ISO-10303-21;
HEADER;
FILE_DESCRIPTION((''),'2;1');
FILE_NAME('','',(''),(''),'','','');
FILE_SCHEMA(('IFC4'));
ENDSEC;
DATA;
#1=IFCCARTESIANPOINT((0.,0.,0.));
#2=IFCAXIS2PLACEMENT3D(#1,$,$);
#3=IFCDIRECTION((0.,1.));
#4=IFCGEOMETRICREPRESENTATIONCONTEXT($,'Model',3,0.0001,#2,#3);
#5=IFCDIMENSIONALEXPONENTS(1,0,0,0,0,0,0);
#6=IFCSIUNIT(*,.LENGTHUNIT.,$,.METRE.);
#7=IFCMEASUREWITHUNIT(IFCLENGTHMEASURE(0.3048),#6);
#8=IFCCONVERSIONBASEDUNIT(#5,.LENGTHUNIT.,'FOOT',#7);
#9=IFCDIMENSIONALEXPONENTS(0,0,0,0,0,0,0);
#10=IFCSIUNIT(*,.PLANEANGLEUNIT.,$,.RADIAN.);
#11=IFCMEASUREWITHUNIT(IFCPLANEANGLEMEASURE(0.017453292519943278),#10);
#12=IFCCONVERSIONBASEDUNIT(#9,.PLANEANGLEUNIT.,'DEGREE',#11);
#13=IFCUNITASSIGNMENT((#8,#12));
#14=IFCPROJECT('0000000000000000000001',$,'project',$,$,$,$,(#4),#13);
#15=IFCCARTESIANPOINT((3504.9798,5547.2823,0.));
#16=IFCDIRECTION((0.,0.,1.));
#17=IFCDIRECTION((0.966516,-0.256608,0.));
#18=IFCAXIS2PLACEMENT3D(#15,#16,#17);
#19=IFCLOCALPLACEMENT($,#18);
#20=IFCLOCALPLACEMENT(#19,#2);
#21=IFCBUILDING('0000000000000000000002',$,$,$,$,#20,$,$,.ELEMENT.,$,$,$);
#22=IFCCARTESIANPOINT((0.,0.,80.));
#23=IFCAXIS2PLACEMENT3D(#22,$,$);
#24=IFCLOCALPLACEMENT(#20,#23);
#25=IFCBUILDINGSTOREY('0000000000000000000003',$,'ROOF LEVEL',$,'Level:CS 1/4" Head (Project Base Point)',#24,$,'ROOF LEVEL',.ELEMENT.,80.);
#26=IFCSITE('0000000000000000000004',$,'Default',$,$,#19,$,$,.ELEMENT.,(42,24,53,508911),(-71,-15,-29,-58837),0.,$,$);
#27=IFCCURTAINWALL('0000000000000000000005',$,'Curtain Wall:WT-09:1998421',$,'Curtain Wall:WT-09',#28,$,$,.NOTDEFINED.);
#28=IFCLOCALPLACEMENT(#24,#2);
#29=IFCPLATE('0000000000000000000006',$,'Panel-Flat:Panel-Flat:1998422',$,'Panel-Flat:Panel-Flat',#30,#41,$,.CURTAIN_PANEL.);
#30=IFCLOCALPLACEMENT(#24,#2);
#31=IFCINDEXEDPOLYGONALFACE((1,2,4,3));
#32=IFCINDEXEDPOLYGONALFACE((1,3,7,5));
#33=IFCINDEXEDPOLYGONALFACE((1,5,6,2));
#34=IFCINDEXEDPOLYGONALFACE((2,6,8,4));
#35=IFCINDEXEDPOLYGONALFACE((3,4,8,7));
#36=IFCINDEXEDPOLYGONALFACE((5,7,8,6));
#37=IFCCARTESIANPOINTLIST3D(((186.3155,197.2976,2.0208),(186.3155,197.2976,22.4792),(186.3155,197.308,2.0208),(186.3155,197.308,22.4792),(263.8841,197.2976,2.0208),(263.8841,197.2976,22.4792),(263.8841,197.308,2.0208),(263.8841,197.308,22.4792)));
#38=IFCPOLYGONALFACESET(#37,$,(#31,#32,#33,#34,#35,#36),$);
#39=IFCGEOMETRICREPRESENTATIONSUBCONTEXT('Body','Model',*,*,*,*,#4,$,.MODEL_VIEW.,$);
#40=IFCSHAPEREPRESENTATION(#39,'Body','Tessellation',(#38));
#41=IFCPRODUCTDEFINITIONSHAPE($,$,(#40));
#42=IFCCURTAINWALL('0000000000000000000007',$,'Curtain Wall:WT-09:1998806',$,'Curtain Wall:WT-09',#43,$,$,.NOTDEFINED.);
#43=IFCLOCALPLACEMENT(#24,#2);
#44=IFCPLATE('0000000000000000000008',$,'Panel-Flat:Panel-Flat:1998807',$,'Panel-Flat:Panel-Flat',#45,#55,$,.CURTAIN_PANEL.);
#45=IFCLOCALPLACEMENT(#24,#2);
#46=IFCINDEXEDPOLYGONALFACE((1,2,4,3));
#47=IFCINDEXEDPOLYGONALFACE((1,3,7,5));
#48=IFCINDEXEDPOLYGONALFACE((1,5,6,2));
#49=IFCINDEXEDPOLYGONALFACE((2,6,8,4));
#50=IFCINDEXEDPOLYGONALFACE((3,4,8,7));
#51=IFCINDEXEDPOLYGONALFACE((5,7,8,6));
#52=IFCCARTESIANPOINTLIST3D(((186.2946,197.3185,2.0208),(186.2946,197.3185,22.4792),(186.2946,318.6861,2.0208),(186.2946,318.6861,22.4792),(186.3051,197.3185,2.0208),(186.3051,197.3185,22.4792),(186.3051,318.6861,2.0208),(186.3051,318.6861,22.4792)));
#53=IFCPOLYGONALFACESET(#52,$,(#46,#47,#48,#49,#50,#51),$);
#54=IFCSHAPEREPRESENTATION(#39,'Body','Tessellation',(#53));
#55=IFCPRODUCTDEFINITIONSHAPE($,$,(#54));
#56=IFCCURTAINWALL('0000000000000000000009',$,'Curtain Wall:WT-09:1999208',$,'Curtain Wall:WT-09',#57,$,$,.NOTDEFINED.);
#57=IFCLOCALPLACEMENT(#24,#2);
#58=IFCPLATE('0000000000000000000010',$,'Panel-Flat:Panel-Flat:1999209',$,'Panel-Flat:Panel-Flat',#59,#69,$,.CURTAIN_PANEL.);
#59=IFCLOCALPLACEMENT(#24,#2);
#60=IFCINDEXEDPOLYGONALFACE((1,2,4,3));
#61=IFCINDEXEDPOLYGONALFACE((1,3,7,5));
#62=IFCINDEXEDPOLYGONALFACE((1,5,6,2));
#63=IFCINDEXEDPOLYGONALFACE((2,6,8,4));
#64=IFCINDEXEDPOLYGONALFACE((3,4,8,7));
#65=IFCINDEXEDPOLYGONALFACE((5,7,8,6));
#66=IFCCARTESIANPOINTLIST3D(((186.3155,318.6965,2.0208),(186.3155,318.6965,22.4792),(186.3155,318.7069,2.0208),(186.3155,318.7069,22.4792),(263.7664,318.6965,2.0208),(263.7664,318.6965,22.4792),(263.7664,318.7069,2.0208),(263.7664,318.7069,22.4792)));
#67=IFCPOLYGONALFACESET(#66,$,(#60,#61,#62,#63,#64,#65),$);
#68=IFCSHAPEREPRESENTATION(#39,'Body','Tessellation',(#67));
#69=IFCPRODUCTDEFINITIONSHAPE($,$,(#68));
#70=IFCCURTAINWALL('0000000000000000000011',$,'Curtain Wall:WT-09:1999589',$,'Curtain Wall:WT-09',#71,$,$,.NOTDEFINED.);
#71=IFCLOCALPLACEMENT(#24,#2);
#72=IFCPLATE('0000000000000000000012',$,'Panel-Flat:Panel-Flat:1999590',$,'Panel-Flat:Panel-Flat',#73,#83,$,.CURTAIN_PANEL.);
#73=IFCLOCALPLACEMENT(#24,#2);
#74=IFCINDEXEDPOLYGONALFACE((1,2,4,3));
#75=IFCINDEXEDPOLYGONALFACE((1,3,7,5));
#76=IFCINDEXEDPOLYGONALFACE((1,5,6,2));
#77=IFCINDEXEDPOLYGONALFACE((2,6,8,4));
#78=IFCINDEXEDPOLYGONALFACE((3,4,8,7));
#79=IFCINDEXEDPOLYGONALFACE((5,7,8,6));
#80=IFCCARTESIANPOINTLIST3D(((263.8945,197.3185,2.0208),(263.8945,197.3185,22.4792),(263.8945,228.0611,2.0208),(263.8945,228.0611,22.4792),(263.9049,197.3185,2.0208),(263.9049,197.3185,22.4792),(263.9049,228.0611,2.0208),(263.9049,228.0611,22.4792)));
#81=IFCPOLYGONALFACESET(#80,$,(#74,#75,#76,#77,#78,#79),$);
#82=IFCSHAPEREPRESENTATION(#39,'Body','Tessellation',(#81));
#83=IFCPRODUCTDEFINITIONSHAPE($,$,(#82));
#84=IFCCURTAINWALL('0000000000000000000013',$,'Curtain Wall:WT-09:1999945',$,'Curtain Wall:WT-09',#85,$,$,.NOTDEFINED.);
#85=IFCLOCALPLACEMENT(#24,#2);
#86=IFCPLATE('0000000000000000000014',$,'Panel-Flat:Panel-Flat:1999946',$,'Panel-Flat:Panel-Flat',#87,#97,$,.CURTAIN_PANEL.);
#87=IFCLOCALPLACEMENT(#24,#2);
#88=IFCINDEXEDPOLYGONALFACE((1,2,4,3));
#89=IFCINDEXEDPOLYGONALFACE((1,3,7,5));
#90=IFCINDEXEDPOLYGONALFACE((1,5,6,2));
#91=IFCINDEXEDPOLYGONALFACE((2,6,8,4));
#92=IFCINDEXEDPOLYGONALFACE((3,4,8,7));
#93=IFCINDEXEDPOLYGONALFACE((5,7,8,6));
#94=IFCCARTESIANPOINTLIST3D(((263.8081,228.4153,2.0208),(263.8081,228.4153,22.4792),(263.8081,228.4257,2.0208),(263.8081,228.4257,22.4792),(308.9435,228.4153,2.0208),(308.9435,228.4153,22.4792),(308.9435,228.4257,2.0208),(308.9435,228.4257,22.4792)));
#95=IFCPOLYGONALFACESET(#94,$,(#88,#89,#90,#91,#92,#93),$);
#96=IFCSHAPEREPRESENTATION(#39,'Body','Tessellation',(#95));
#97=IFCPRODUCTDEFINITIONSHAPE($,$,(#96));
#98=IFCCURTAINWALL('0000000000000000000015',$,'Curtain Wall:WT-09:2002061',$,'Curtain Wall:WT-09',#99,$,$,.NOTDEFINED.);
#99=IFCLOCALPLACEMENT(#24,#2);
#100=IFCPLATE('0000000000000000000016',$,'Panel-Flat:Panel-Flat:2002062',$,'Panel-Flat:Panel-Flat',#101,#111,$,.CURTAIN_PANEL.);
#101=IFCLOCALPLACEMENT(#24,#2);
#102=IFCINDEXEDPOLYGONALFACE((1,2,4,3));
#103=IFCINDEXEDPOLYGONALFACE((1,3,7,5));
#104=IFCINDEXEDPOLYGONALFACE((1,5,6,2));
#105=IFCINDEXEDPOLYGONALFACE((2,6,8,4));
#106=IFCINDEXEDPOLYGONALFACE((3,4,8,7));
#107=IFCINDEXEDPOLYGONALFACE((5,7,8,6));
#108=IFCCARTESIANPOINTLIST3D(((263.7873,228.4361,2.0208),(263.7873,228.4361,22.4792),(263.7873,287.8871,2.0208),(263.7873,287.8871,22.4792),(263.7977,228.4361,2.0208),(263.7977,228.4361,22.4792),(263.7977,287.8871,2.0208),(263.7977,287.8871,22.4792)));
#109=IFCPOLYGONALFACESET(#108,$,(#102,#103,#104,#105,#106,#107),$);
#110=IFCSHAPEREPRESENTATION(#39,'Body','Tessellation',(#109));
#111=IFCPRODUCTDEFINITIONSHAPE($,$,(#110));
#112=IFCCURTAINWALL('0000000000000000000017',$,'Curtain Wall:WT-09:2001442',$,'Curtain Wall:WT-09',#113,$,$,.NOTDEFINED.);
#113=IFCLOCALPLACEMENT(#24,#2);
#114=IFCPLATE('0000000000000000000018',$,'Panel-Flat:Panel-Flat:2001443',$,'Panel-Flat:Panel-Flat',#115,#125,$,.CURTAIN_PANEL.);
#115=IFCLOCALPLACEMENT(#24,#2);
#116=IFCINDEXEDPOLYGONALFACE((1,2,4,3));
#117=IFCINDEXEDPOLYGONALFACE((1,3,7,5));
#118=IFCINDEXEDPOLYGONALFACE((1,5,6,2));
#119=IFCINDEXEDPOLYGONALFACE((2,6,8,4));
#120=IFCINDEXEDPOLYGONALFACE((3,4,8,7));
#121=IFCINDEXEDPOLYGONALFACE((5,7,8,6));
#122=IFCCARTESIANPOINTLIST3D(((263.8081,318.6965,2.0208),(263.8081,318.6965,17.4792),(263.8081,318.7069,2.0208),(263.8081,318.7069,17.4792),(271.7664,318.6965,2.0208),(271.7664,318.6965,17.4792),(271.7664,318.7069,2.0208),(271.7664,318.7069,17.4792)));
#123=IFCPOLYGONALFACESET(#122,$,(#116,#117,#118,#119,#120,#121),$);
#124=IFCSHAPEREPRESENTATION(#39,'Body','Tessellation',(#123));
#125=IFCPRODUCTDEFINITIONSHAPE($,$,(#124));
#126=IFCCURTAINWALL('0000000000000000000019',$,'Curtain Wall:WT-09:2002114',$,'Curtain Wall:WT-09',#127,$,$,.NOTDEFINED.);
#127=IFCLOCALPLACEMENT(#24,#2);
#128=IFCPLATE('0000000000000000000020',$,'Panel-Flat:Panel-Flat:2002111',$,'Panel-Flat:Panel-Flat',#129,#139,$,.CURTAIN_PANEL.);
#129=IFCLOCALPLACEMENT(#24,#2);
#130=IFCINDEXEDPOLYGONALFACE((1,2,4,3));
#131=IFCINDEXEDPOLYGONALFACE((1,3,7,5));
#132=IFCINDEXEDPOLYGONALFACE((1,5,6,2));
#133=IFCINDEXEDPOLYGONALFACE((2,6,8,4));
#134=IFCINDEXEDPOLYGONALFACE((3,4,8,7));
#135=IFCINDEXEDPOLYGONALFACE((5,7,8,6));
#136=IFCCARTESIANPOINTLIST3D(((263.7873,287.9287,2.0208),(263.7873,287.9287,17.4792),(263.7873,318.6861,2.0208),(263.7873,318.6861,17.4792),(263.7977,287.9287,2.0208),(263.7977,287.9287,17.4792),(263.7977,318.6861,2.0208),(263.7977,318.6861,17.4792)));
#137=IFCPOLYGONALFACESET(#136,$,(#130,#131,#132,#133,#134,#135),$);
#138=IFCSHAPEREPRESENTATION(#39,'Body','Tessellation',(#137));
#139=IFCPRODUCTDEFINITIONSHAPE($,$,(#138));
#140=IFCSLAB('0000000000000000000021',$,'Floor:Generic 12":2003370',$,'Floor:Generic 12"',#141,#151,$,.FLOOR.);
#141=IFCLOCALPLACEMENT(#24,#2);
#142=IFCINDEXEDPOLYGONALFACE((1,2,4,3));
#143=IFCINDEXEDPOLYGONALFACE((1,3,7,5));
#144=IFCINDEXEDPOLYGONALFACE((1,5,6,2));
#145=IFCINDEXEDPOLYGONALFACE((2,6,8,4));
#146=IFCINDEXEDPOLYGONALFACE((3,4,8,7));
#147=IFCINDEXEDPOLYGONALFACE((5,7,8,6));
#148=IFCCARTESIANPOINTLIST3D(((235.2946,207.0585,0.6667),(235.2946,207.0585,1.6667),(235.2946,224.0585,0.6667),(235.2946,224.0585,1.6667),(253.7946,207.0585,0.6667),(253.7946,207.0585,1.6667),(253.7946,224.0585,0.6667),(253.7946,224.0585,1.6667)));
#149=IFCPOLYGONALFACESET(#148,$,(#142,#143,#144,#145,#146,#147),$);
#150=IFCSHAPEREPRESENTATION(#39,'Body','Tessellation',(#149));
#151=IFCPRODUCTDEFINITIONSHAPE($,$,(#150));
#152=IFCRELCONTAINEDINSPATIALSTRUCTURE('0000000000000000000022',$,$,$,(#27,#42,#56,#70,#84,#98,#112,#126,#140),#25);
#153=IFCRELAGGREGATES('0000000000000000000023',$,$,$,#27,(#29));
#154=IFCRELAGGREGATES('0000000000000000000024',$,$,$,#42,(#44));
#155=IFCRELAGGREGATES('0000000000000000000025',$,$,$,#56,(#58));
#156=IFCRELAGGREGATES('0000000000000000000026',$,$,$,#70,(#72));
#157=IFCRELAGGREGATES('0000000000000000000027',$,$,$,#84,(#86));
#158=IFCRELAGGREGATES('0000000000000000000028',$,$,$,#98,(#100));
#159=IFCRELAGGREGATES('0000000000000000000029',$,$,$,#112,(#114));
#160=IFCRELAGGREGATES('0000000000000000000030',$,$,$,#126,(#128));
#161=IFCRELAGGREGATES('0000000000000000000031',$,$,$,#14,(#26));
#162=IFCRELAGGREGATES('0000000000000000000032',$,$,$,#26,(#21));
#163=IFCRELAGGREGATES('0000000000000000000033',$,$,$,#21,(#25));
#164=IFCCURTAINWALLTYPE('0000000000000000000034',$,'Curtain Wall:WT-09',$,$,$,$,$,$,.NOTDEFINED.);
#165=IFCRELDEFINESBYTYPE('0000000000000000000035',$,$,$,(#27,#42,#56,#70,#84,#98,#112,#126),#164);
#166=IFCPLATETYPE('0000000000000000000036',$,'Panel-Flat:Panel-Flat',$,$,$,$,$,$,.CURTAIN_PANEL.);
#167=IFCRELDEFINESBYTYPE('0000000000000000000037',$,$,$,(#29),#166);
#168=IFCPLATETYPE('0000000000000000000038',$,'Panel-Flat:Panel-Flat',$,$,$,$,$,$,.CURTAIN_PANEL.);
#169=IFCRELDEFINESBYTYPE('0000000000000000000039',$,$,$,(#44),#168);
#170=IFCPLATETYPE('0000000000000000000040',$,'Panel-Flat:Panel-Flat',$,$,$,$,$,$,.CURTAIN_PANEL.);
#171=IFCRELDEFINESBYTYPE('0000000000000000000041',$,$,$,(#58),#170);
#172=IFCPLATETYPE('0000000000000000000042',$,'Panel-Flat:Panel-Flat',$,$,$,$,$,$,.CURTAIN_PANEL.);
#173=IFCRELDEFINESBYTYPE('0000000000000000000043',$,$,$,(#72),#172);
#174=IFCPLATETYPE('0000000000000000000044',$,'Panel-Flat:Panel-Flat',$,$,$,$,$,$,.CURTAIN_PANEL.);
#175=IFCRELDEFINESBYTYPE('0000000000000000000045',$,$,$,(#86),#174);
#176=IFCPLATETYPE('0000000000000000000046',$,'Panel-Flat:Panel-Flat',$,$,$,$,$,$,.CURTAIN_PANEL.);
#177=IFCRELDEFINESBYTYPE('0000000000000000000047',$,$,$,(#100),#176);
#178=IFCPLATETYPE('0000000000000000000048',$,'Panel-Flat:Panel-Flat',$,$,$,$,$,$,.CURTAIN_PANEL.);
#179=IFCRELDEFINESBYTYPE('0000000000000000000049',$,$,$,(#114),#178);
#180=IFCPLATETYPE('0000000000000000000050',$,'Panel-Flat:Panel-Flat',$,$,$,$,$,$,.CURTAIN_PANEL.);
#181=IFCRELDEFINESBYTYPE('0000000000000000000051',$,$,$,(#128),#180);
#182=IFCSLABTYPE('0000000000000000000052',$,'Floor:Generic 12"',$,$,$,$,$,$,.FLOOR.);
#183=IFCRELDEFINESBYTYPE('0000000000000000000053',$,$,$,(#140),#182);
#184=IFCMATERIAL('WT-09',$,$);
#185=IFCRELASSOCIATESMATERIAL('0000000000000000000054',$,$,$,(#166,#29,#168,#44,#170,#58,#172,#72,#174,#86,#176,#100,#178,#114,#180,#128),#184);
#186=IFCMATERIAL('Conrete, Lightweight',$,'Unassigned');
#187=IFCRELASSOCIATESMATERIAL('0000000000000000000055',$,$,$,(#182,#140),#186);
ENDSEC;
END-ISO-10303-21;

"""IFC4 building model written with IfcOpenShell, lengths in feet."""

from ifc_helpers import new_model, entity, si_unit, converted_unit, direction, frame, origin, place, context, subcontext, project, spatial, indexed_curve, outline, extrude, source, transform, mapped, material, type_object, type_shapes, element, aggregate, save


model = new_model("IFC4")

# Units and contexts
model_context = context("Model", 3, precision=0.0001, world=origin(), true_north=direction((0.0, 1.0)))
body_context = subcontext(model_context, "Body", "Model", "MODEL_VIEW")
ifc_project = project(units=[converted_unit("LENGTHUNIT", "FOOT", entity("IfcLengthMeasure", 0.3048), si_unit("LENGTHUNIT", "METRE"), dimensions=[1, 0, 0, 0, 0, 0, 0]), converted_unit("PLANEANGLEUNIT", "DEGREE", entity("IfcPlaneAngleMeasure", 0.017453292519943278), si_unit("PLANEANGLEUNIT", "RADIAN"), dimensions=[0, 0, 0, 0, 0, 0, 0])], contexts=[model_context])

# Site, building, storey
site_placement = place(None, frame((3504.9798, 5547.2823, 0.0), z_axis=(0.0, 0.0, 1.0), x_axis=(0.966516, -0.256608, 0.0)))
site = spatial("IfcSite", under=ifc_project, at=site_placement, Name="Default", CompositionType="ELEMENT", RefLatitude=(42, 24, 53, 508911), RefLongitude=(-71, -15, -29, -58837), RefElevation=0.0)
building_placement = place(site_placement, origin())
building = spatial("IfcBuilding", under=site, at=building_placement, CompositionType="ELEMENT")
storey_placement = place(building_placement, frame((0.0, 0.0, 80.0)))
storey = spatial("IfcBuildingStorey", under=building, at=storey_placement, Name="ROOF LEVEL", ObjectType="Level:CS 1/4\" Head (Project Base Point)", LongName="ROOF LEVEL", CompositionType="ELEMENT", Elevation=80.0)

# Curtain walls, plates
curtain_wall_type_1 = type_object("IfcCurtainWallType", Name="Curtain Wall:WT-09", PredefinedType="NOTDEFINED")
curtain_wall_1_placement = place(storey_placement, frame((0.0, 0.0, -80.0)))
curtain_wall_1 = element("IfcCurtainWall", 1, at=curtain_wall_1_placement, inside=storey, type_object=curtain_wall_type_1, Name="Curtain Wall:WT-09:1998421", ObjectType="Curtain Wall:WT-09", PredefinedType="NOTDEFINED")
ifc_material_1 = material(Name="WT-09")
plate_type_1 = type_object("IfcPlateType", Name="Panel-Flat:Panel-Flat", PredefinedType="CURTAIN_PANEL", material=ifc_material_1)
shared_shape_1 = source(origin(), body_context, "Body", "SweptSolid", [
    extrude(outline(indexed_curve([(-0.0052, -38.7843), (0.0052, -38.7843), (0.0052, 38.7843), (-0.0052, 38.7843), (-0.0052, -38.7843)], self_intersect=False)), frame((0.0, -0.0052, 0.0208), z_axis=(0.0, 0.0, 1.0), x_axis=(0.0, -1.0, 0.0)), (0.0, 0.0, 1.0), 20.4583),
])
type_shapes(plate_type_1, [shared_shape_1])
plate_1_placement = place(curtain_wall_1_placement, frame((225.0998, 197.2976, 82.0), z_axis=(0.0, 0.0, 1.0), x_axis=(-1.0, 0.0, 0.0)))
plate_1 = element("IfcPlate", 2, at=plate_1_placement, type_object=plate_type_1, material=ifc_material_1, Name="Panel-Flat:Panel-Flat:1998422", ObjectType="Panel-Flat:Panel-Flat", PredefinedType="CURTAIN_PANEL", context=body_context, shape_type="MappedRepresentation", body=[
    mapped(shared_shape_1, transform((0.0, 0.0, 0.0), scale=1.0)),
])
aggregate(curtain_wall_1, [plate_1])
curtain_wall_2_placement = place(storey_placement, frame((0.0, 0.0, -80.0)))
curtain_wall_2 = element("IfcCurtainWall", 3, at=curtain_wall_2_placement, inside=storey, type_object=curtain_wall_type_1, Name="Curtain Wall:WT-09:1998806", ObjectType="Curtain Wall:WT-09", PredefinedType="NOTDEFINED")
plate_type_2 = type_object("IfcPlateType", Name="Panel-Flat:Panel-Flat", PredefinedType="CURTAIN_PANEL", material=ifc_material_1)
shared_shape_2 = source(origin(), body_context, "Body", "SweptSolid", [
    extrude(outline(indexed_curve([(-0.0052, -60.6838), (0.0052, -60.6838), (0.0052, 60.6838), (-0.0052, 60.6838), (-0.0052, -60.6838)], self_intersect=False)), frame((0.0, -0.0052, 0.0208), z_axis=(0.0, 0.0, 1.0), x_axis=(0.0, -1.0, 0.0)), (0.0, 0.0, 1.0), 20.4583),
])
type_shapes(plate_type_2, [shared_shape_2])
plate_2_placement = place(curtain_wall_2_placement, frame((186.2946, 258.0023, 82.0), z_axis=(0.0, 0.0, 1.0), x_axis=(0.0, 1.0, 0.0)))
plate_2 = element("IfcPlate", 4, at=plate_2_placement, type_object=plate_type_2, material=ifc_material_1, Name="Panel-Flat:Panel-Flat:1998807", ObjectType="Panel-Flat:Panel-Flat", PredefinedType="CURTAIN_PANEL", context=body_context, shape_type="MappedRepresentation", body=[
    mapped(shared_shape_2, transform((0.0, 0.0, 0.0), scale=1.0)),
])
aggregate(curtain_wall_2, [plate_2])
curtain_wall_3_placement = place(storey_placement, frame((0.0, 0.0, -80.0)))
curtain_wall_3 = element("IfcCurtainWall", 5, at=curtain_wall_3_placement, inside=storey, type_object=curtain_wall_type_1, Name="Curtain Wall:WT-09:1999208", ObjectType="Curtain Wall:WT-09", PredefinedType="NOTDEFINED")
plate_type_3 = type_object("IfcPlateType", Name="Panel-Flat:Panel-Flat", PredefinedType="CURTAIN_PANEL", material=ifc_material_1)
shared_shape_3 = source(origin(), body_context, "Body", "SweptSolid", [
    extrude(outline(indexed_curve([(-0.0052, -38.7255), (0.0052, -38.7255), (0.0052, 38.7255), (-0.0052, 38.7255), (-0.0052, -38.7255)], self_intersect=False)), frame((0.0, -0.0052, 0.0208), z_axis=(0.0, 0.0, 1.0), x_axis=(0.0, -1.0, 0.0)), (0.0, 0.0, 1.0), 20.4583),
])
type_shapes(plate_type_3, [shared_shape_3])
plate_3_placement = place(curtain_wall_3_placement, frame((225.041, 318.7069, 82.0)))
plate_3 = element("IfcPlate", 6, at=plate_3_placement, type_object=plate_type_3, material=ifc_material_1, Name="Panel-Flat:Panel-Flat:1999209", ObjectType="Panel-Flat:Panel-Flat", PredefinedType="CURTAIN_PANEL", context=body_context, shape_type="MappedRepresentation", body=[
    mapped(shared_shape_3, transform((0.0, 0.0, 0.0), scale=1.0)),
])
aggregate(curtain_wall_3, [plate_3])
curtain_wall_4_placement = place(storey_placement, frame((0.0, 0.0, -80.0)))
curtain_wall_4 = element("IfcCurtainWall", 7, at=curtain_wall_4_placement, inside=storey, type_object=curtain_wall_type_1, Name="Curtain Wall:WT-09:1999589", ObjectType="Curtain Wall:WT-09", PredefinedType="NOTDEFINED")
plate_type_4 = type_object("IfcPlateType", Name="Panel-Flat:Panel-Flat", PredefinedType="CURTAIN_PANEL", material=ifc_material_1)
shared_shape_4 = source(origin(), body_context, "Body", "SweptSolid", [
    extrude(outline(indexed_curve([(-0.0052, -15.3713), (0.0052, -15.3713), (0.0052, 15.3713), (-0.0052, 15.3713), (-0.0052, -15.3713)], self_intersect=False)), frame((0.0, -0.0052, 0.0208), z_axis=(0.0, 0.0, 1.0), x_axis=(0.0, -1.0, 0.0)), (0.0, 0.0, 1.0), 20.4583),
])
type_shapes(plate_type_4, [shared_shape_4])
plate_4_placement = place(curtain_wall_4_placement, frame((263.9049, 212.6898, 82.0), z_axis=(0.0, 0.0, 1.0), x_axis=(0.0, -1.0, 0.0)))
plate_4 = element("IfcPlate", 8, at=plate_4_placement, type_object=plate_type_4, material=ifc_material_1, Name="Panel-Flat:Panel-Flat:1999590", ObjectType="Panel-Flat:Panel-Flat", PredefinedType="CURTAIN_PANEL", context=body_context, shape_type="MappedRepresentation", body=[
    mapped(shared_shape_4, transform((0.0, 0.0, 0.0), scale=1.0)),
])
aggregate(curtain_wall_4, [plate_4])
curtain_wall_5_placement = place(storey_placement, frame((0.0, 0.0, -80.0)))
curtain_wall_5 = element("IfcCurtainWall", 9, at=curtain_wall_5_placement, inside=storey, type_object=curtain_wall_type_1, Name="Curtain Wall:WT-09:1999945", ObjectType="Curtain Wall:WT-09", PredefinedType="NOTDEFINED")
plate_type_5 = type_object("IfcPlateType", Name="Panel-Flat:Panel-Flat", PredefinedType="CURTAIN_PANEL", material=ifc_material_1)
shared_shape_5 = source(origin(), body_context, "Body", "SweptSolid", [
    extrude(outline(indexed_curve([(-0.0052, -22.5677), (0.0052, -22.5677), (0.0052, 22.5677), (-0.0052, 22.5677), (-0.0052, -22.5677)], self_intersect=False)), frame((0.0, -0.0052, 0.0208), z_axis=(0.0, 0.0, 1.0), x_axis=(0.0, -1.0, 0.0)), (0.0, 0.0, 1.0), 20.4583),
])
type_shapes(plate_type_5, [shared_shape_5])
plate_5_placement = place(curtain_wall_5_placement, frame((286.3758, 228.4153, 82.0), z_axis=(0.0, 0.0, 1.0), x_axis=(-1.0, 0.0, 0.0)))
plate_5 = element("IfcPlate", 10, at=plate_5_placement, type_object=plate_type_5, material=ifc_material_1, Name="Panel-Flat:Panel-Flat:1999946", ObjectType="Panel-Flat:Panel-Flat", PredefinedType="CURTAIN_PANEL", context=body_context, shape_type="MappedRepresentation", body=[
    mapped(shared_shape_5, transform((0.0, 0.0, 0.0), scale=1.0)),
])
aggregate(curtain_wall_5, [plate_5])
curtain_wall_6_placement = place(storey_placement, frame((0.0, 0.0, -80.0)))
curtain_wall_6 = element("IfcCurtainWall", 11, at=curtain_wall_6_placement, inside=storey, type_object=curtain_wall_type_1, Name="Curtain Wall:WT-09:2002061", ObjectType="Curtain Wall:WT-09", PredefinedType="NOTDEFINED")
plate_type_6 = type_object("IfcPlateType", Name="Panel-Flat:Panel-Flat", PredefinedType="CURTAIN_PANEL", material=ifc_material_1)
shared_shape_6 = source(origin(), body_context, "Body", "SweptSolid", [
    extrude(outline(indexed_curve([(-0.0052, -29.7255), (0.0052, -29.7255), (0.0052, 29.7255), (-0.0052, 29.7255), (-0.0052, -29.7255)], self_intersect=False)), frame((0.0, -0.0052, 0.0208), z_axis=(0.0, 0.0, 1.0), x_axis=(0.0, -1.0, 0.0)), (0.0, 0.0, 1.0), 20.4583),
])
type_shapes(plate_type_6, [shared_shape_6])
plate_6_placement = place(curtain_wall_6_placement, frame((263.7873, 258.1616, 82.0), z_axis=(0.0, 0.0, 1.0), x_axis=(0.0, 1.0, 0.0)))
plate_6 = element("IfcPlate", 12, at=plate_6_placement, type_object=plate_type_6, material=ifc_material_1, Name="Panel-Flat:Panel-Flat:2002062", ObjectType="Panel-Flat:Panel-Flat", PredefinedType="CURTAIN_PANEL", context=body_context, shape_type="MappedRepresentation", body=[
    mapped(shared_shape_6, transform((0.0, 0.0, 0.0), scale=1.0)),
])
aggregate(curtain_wall_6, [plate_6])
curtain_wall_7_placement = place(storey_placement, frame((0.0, 0.0, -80.0)))
curtain_wall_7 = element("IfcCurtainWall", 13, at=curtain_wall_7_placement, inside=storey, type_object=curtain_wall_type_1, Name="Curtain Wall:WT-09:2001442", ObjectType="Curtain Wall:WT-09", PredefinedType="NOTDEFINED")
plate_type_7 = type_object("IfcPlateType", Name="Panel-Flat:Panel-Flat", PredefinedType="CURTAIN_PANEL", material=ifc_material_1)
shared_shape_7 = source(origin(), body_context, "Body", "SweptSolid", [
    extrude(outline(indexed_curve([(-0.0052, -3.9792), (0.0052, -3.9792), (0.0052, 3.9792), (-0.0052, 3.9792), (-0.0052, -3.9792)], self_intersect=False)), frame((0.0, -0.0052, 0.0208), z_axis=(0.0, 0.0, 1.0), x_axis=(0.0, -1.0, 0.0)), (0.0, 0.0, 1.0), 15.4583),
])
type_shapes(plate_type_7, [shared_shape_7])
plate_7_placement = place(curtain_wall_7_placement, frame((267.7873, 318.7069, 82.0)))
plate_7 = element("IfcPlate", 14, at=plate_7_placement, type_object=plate_type_7, material=ifc_material_1, Name="Panel-Flat:Panel-Flat:2001443", ObjectType="Panel-Flat:Panel-Flat", PredefinedType="CURTAIN_PANEL", context=body_context, shape_type="MappedRepresentation", body=[
    mapped(shared_shape_7, transform((0.0, 0.0, 0.0), scale=1.0)),
])
aggregate(curtain_wall_7, [plate_7])
curtain_wall_8_placement = place(storey_placement, frame((0.0, 0.0, -80.0)))
curtain_wall_8 = element("IfcCurtainWall", 15, at=curtain_wall_8_placement, inside=storey, type_object=curtain_wall_type_1, Name="Curtain Wall:WT-09:2002114", ObjectType="Curtain Wall:WT-09", PredefinedType="NOTDEFINED")
plate_type_8 = type_object("IfcPlateType", Name="Panel-Flat:Panel-Flat", PredefinedType="CURTAIN_PANEL", material=ifc_material_1)
shared_shape_8 = source(origin(), body_context, "Body", "SweptSolid", [
    extrude(outline(indexed_curve([(-0.0052, -15.3787), (0.0052, -15.3787), (0.0052, 15.3787), (-0.0052, 15.3787), (-0.0052, -15.3787)], self_intersect=False)), frame((0.0, -0.0052, 0.0208), z_axis=(0.0, 0.0, 1.0), x_axis=(0.0, -1.0, 0.0)), (0.0, 0.0, 1.0), 15.4583),
])
type_shapes(plate_type_8, [shared_shape_8])
plate_8_placement = place(curtain_wall_8_placement, frame((263.7873, 303.3074, 82.0), z_axis=(0.0, 0.0, 1.0), x_axis=(0.0, 1.0, 0.0)))
plate_8 = element("IfcPlate", 16, at=plate_8_placement, type_object=plate_type_8, material=ifc_material_1, Name="Panel-Flat:Panel-Flat:2002111", ObjectType="Panel-Flat:Panel-Flat", PredefinedType="CURTAIN_PANEL", context=body_context, shape_type="MappedRepresentation", body=[
    mapped(shared_shape_8, transform((0.0, 0.0, 0.0), scale=1.0)),
])
aggregate(curtain_wall_8, [plate_8])

# Slab
ifc_material_2 = material(Name="Conrete, Lightweight", Category="Unassigned")
slab_type = type_object("IfcSlabType", Name="Floor:Generic 12\"", PredefinedType="FLOOR", material=ifc_material_2)
slab_1_placement = place(storey_placement, origin())
element("IfcSlab", 17, at=slab_1_placement, inside=storey, type_object=slab_type, material=ifc_material_2, Name="Floor:Generic 12\":2003370", ObjectType="Floor:Generic 12\"", PredefinedType="FLOOR", context=body_context, shape_type="SweptSolid", body=[
    extrude(outline(indexed_curve([(-8.5, -9.25), (8.5, -9.25), (8.5, 9.25), (-8.5, 9.25), (-8.5, -9.25)], self_intersect=False)), frame((244.5446, 215.5585, 1.6667), z_axis=(0.0, 0.0, -1.0), x_axis=(0.0, 1.0, 0.0)), (0.0, 0.0, 1.0), 1.0),
])

save(model, "model.ifc")
